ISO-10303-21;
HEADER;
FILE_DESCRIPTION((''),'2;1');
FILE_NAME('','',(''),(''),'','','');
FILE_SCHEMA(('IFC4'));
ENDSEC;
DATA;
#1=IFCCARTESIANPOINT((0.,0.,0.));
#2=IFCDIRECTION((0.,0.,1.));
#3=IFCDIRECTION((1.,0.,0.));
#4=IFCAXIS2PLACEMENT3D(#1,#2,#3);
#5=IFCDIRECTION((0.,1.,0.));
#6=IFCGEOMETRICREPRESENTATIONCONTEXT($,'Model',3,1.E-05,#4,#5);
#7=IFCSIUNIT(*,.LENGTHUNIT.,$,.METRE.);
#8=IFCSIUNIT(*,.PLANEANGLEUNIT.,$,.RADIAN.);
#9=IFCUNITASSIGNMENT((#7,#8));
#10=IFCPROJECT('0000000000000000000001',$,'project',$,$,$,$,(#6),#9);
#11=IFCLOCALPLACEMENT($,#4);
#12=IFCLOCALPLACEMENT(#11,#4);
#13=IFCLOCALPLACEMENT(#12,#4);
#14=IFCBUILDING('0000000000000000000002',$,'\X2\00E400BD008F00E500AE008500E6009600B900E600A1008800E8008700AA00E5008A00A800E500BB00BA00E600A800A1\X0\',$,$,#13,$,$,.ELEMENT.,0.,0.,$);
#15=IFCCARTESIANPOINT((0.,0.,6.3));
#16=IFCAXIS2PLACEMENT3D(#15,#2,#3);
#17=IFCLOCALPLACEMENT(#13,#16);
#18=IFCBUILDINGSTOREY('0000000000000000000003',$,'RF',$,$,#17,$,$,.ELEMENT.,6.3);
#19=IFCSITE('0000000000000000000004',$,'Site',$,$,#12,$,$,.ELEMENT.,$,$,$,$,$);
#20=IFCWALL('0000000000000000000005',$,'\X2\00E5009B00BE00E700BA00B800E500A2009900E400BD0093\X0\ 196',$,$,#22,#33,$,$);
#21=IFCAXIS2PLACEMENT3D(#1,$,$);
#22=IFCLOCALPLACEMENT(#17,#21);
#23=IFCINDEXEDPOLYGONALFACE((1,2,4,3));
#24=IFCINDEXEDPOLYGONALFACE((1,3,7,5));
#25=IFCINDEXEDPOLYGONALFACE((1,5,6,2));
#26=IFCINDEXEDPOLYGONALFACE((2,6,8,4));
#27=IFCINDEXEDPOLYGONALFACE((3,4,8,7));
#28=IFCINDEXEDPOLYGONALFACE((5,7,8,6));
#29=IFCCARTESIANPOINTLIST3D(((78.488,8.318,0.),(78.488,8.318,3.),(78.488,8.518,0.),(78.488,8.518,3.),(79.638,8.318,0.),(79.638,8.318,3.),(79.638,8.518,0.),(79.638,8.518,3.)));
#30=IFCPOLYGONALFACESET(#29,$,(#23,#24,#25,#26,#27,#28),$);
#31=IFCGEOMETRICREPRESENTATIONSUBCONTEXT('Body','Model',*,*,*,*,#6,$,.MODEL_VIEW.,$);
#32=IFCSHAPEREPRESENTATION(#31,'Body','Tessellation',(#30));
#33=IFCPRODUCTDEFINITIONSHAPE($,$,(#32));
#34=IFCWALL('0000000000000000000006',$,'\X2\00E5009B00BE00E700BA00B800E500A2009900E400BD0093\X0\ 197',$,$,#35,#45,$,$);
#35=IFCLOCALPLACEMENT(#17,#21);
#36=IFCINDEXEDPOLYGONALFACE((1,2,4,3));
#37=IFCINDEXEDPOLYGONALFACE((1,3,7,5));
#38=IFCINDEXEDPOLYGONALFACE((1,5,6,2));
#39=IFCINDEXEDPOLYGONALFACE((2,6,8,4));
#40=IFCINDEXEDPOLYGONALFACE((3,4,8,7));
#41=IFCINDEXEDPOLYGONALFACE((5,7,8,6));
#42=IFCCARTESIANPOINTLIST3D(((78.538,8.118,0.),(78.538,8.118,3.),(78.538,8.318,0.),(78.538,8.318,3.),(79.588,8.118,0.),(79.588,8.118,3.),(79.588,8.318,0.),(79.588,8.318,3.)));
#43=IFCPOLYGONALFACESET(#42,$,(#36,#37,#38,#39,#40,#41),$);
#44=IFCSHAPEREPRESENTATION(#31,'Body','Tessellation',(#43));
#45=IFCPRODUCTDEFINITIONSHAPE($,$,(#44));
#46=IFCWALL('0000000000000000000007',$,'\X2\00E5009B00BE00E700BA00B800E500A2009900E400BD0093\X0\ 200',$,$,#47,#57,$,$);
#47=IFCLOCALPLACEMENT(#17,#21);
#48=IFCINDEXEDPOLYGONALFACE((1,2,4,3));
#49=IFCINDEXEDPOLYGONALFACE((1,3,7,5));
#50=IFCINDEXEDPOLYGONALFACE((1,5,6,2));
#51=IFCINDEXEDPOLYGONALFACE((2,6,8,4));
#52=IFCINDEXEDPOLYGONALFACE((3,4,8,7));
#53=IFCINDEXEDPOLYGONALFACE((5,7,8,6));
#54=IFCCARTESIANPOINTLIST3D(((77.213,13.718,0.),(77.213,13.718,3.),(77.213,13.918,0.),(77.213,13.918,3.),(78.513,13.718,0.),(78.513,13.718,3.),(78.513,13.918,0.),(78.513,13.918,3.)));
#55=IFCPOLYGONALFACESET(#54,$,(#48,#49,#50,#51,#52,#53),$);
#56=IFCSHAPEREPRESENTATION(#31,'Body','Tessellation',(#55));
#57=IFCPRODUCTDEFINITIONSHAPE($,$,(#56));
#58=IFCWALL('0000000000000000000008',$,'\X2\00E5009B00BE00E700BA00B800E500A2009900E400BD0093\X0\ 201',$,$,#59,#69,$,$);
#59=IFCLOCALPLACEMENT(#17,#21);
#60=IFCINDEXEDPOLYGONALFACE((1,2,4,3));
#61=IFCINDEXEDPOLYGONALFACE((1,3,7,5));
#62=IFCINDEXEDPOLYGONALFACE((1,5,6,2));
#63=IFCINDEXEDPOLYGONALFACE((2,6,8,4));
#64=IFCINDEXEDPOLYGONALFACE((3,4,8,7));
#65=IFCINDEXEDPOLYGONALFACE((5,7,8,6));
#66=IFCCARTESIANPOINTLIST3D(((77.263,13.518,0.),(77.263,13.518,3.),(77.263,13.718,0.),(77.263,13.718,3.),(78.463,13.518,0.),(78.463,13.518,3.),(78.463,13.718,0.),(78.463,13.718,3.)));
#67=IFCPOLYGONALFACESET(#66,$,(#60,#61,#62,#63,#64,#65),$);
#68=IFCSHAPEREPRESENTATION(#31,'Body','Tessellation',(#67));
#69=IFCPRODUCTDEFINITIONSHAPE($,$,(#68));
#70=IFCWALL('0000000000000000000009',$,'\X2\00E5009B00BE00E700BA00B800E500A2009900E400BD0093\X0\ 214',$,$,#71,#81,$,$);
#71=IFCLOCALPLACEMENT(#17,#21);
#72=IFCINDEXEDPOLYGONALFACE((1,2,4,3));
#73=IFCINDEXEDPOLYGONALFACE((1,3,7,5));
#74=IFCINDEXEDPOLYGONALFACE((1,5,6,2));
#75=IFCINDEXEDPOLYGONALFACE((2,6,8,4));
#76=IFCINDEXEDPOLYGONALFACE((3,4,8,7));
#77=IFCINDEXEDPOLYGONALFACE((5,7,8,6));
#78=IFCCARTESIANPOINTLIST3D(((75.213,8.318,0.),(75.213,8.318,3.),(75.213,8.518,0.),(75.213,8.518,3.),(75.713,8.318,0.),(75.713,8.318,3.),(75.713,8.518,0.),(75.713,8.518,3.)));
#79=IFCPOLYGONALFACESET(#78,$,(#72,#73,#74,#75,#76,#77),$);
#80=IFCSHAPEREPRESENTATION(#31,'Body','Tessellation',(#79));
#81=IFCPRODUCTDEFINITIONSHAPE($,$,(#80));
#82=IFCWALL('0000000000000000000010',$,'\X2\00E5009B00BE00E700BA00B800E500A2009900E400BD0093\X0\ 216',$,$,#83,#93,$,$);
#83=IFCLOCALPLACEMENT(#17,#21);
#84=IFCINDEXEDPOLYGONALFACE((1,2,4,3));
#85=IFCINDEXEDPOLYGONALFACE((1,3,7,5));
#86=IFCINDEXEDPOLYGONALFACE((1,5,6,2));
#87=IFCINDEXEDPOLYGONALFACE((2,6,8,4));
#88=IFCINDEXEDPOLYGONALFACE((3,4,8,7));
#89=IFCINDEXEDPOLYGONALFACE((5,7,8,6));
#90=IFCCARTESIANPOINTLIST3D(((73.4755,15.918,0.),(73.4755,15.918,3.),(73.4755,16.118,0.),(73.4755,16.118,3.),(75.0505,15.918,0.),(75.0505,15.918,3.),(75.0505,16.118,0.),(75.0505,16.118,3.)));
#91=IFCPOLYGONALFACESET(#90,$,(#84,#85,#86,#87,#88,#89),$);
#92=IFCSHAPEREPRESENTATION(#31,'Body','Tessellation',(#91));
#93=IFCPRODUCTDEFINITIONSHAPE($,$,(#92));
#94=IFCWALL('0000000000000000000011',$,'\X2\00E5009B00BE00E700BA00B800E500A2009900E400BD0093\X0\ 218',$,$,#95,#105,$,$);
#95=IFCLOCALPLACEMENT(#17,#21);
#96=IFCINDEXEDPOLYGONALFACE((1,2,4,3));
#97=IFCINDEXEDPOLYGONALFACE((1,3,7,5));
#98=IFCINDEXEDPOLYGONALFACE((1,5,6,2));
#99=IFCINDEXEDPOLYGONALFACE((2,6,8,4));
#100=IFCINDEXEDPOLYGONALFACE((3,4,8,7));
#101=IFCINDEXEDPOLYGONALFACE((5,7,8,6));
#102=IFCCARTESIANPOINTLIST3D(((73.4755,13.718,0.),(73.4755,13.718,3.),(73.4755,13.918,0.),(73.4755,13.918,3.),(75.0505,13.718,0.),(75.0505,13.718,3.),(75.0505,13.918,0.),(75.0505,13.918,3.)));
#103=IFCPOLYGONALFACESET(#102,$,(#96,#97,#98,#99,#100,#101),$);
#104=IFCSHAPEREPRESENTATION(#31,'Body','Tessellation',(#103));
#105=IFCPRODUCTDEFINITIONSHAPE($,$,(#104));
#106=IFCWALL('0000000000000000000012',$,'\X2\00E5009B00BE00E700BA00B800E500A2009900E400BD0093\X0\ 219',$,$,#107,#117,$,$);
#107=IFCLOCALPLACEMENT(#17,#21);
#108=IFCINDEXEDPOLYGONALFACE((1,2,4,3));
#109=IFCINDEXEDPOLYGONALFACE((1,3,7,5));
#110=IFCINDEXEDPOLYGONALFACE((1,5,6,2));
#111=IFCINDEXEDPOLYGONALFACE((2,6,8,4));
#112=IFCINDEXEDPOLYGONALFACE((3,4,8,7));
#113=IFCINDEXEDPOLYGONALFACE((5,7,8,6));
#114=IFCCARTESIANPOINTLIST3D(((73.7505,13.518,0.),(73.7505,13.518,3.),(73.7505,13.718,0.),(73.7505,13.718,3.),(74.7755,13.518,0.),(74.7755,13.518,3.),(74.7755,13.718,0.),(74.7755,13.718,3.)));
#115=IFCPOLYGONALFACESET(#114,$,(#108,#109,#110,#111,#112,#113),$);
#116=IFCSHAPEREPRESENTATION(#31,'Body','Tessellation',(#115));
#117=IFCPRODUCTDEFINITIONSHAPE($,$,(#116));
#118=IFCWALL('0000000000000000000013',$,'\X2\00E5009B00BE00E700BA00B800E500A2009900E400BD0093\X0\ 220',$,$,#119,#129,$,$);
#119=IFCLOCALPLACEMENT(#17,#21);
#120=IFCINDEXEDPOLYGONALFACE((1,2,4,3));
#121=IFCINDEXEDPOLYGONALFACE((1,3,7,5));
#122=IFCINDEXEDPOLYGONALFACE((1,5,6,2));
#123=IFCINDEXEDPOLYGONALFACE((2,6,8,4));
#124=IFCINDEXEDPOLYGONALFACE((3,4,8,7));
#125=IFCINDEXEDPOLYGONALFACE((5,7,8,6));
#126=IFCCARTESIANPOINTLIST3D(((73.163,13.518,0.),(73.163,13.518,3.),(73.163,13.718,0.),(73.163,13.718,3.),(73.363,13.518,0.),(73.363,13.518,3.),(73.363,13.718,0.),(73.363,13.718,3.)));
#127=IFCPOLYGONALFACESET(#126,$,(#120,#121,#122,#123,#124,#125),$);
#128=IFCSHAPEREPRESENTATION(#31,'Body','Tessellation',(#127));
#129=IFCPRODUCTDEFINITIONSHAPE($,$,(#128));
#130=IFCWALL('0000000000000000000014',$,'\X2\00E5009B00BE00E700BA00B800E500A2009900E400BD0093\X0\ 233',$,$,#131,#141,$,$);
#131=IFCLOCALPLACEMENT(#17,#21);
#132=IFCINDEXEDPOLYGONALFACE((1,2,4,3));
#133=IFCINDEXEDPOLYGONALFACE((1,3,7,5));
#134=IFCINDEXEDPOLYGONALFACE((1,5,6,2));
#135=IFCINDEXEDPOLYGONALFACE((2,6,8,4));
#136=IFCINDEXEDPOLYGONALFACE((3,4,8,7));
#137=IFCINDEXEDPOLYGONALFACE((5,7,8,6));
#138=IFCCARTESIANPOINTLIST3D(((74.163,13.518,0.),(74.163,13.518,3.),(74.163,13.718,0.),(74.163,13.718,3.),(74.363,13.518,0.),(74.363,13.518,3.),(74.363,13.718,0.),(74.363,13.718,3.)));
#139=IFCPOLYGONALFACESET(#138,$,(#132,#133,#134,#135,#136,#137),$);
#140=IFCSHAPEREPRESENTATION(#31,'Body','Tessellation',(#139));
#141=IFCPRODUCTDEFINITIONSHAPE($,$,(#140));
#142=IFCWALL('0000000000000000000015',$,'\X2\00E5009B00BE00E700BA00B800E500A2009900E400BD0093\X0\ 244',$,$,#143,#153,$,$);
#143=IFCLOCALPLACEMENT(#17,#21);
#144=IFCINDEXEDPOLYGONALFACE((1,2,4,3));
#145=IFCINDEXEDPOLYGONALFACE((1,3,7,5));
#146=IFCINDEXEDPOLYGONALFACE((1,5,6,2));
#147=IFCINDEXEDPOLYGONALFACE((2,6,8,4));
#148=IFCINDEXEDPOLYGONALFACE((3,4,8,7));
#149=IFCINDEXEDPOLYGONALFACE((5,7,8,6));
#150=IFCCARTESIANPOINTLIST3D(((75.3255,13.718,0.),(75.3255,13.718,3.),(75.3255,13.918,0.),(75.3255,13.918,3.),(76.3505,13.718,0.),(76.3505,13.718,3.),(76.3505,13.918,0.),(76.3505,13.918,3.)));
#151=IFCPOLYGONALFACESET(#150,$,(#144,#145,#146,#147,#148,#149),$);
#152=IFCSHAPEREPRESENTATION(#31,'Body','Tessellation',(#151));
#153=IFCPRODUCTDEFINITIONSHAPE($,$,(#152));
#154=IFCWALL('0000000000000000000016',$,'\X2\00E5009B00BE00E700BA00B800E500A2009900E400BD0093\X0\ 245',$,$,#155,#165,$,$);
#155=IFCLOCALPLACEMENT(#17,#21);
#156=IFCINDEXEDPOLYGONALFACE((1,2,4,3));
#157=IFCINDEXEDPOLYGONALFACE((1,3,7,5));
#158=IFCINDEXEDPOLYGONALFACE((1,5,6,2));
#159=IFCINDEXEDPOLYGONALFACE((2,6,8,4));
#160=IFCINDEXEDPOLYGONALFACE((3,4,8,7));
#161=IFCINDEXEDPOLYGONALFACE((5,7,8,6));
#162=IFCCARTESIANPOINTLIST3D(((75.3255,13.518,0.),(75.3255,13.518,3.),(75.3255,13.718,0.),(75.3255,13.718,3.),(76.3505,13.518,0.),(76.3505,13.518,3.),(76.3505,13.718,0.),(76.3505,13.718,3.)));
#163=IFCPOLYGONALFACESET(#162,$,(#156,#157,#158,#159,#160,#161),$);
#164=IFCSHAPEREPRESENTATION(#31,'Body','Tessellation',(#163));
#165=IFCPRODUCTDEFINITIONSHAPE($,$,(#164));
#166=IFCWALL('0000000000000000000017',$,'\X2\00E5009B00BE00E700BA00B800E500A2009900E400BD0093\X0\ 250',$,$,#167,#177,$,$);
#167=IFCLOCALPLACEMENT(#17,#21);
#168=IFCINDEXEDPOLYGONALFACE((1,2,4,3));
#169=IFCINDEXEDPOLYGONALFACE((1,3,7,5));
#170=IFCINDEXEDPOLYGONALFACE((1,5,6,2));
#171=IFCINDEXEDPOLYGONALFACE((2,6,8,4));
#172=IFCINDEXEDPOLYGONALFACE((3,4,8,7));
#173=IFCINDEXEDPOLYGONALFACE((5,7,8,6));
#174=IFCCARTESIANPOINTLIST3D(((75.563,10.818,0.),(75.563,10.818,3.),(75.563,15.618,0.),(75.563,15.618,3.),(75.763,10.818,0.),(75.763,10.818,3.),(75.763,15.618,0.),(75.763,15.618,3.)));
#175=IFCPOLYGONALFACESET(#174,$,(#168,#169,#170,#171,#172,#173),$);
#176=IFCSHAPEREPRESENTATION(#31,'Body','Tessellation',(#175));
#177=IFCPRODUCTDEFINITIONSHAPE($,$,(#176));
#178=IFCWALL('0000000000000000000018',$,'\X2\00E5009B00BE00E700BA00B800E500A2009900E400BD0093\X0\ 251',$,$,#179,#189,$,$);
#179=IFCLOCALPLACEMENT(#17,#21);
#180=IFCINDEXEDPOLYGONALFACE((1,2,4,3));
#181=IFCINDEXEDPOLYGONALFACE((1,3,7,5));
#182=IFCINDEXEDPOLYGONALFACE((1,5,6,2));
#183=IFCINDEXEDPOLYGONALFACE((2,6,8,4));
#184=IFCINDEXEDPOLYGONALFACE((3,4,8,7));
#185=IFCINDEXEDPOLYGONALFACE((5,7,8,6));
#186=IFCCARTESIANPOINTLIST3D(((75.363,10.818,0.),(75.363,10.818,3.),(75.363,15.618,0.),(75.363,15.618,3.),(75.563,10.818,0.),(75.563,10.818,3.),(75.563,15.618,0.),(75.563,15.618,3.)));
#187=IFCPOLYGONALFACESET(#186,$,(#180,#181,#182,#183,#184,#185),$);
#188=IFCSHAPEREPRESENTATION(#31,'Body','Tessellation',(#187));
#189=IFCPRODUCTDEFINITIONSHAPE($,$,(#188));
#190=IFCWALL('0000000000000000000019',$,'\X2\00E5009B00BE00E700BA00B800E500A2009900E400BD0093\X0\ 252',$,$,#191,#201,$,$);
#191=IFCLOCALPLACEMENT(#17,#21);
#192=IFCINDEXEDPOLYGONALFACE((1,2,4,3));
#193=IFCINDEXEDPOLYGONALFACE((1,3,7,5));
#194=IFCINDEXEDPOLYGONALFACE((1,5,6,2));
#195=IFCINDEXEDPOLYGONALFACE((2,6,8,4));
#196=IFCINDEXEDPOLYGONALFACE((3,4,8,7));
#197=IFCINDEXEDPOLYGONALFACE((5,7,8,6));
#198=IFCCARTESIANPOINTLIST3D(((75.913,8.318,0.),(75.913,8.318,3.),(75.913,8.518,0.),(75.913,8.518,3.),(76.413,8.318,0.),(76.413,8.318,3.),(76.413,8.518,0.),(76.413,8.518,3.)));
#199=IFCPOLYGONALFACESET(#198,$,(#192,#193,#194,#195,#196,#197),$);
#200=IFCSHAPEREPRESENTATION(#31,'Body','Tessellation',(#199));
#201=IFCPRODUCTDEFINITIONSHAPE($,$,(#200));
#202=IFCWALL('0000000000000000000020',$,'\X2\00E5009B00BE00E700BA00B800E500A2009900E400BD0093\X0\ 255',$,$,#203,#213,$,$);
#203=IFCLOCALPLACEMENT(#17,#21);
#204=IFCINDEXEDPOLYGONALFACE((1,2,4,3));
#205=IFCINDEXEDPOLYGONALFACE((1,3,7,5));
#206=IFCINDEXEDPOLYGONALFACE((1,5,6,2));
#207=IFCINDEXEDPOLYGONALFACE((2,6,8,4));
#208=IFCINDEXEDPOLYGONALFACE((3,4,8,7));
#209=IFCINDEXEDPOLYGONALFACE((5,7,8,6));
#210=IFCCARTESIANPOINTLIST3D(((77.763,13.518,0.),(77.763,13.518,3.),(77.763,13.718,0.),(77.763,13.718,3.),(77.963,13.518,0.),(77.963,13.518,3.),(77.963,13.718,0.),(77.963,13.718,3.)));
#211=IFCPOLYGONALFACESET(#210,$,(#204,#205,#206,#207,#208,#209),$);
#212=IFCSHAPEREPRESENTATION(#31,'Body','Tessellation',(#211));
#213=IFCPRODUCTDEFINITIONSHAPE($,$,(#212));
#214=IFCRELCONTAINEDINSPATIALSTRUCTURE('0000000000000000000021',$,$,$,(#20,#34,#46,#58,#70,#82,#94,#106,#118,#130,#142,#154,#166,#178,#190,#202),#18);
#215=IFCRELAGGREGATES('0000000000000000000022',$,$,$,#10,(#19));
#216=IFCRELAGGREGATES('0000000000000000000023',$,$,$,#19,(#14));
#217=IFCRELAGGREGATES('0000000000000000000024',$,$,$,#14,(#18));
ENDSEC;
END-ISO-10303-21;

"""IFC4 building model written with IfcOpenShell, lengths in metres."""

from ifc_helpers import new_model, si_unit, direction, frame, frame_2d, origin_with_axes, place, context, subcontext, project, spatial, rectangle, extrude, element, save


model = new_model("IFC4")

# Units and contexts
model_context = context("Model", 3, precision=1e-05, world=origin_with_axes(), true_north=direction((0.0, 1.0, 0.0)))
body_context = subcontext(model_context, "Body", "Model", "MODEL_VIEW")
ifc_project = project(units=[si_unit("LENGTHUNIT", "METRE"), si_unit("PLANEANGLEUNIT", "RADIAN")], contexts=[model_context])

# Site, building, storey
placement = place(None, origin_with_axes())
site_placement = place(placement, origin_with_axes())
site = spatial("IfcSite", under=ifc_project, at=site_placement, Name="Site", CompositionType="ELEMENT")
building_placement = place(site_placement, origin_with_axes())
building = spatial("IfcBuilding", under=site, at=building_placement, Name="ä½\u008få®\u0085æ\u0096¹æ¡\u0088è\u0087ªå\u008a¨å»ºæ¨¡", CompositionType="ELEMENT", ElevationOfRefHeight=0.0, ElevationOfTerrain=0.0)
storey_placement = place(building_placement, frame((0.0, 0.0, 6.3), z_axis=(0.0, 0.0, 1.0), x_axis=(1.0, 0.0, 0.0)))
storey = spatial("IfcBuildingStorey", under=building, at=storey_placement, Name="RF", CompositionType="ELEMENT", Elevation=6.3)

# Walls
wall_1_placement = place(storey_placement, frame((79.063, 8.418, 0.0), z_axis=(0.0, 0.0, 1.0), x_axis=(-1.0, 0.0, 0.0)))
element("IfcWall", 1, at=wall_1_placement, inside=storey, Name="å\u009b¾çº¸å¢\u0099ä½\u0093 196", context=body_context, shape_type="SweptSolid", body=[
    extrude(rectangle(XDim=1.15, YDim=0.2, at=frame_2d((0.0, 0.0), x_axis=(1.0, 0.0, 0.0))), frame((0.0, 0.0, 0.0), z_axis=(0.0, 0.0, 1.0)), (0.0, 0.0, 1.0), 3.0),
])
wall_2_placement = place(storey_placement, frame((79.063, 8.218, 0.0), z_axis=(0.0, 0.0, 1.0), x_axis=(-1.0, 0.0, 0.0)))
element("IfcWall", 2, at=wall_2_placement, inside=storey, Name="å\u009b¾çº¸å¢\u0099ä½\u0093 197", context=body_context, shape_type="SweptSolid", body=[
    extrude(rectangle(XDim=1.05, YDim=0.2, at=frame_2d((0.0, 0.0), x_axis=(1.0, 0.0, 0.0))), frame((0.0, 0.0, 0.0), z_axis=(0.0, 0.0, 1.0)), (0.0, 0.0, 1.0), 3.0),
])
wall_3_placement = place(storey_placement, frame((77.863, 13.818, 0.0), z_axis=(0.0, 0.0, 1.0), x_axis=(1.0, 0.0, 0.0)))
element("IfcWall", 3, at=wall_3_placement, inside=storey, Name="å\u009b¾çº¸å¢\u0099ä½\u0093 200", context=body_context, shape_type="SweptSolid", body=[
    extrude(rectangle(XDim=1.3, YDim=0.2, at=frame_2d((0.0, 0.0), x_axis=(1.0, 0.0, 0.0))), frame((0.0, 0.0, 0.0), z_axis=(0.0, 0.0, 1.0)), (0.0, 0.0, 1.0), 3.0),
])
wall_4_placement = place(storey_placement, frame((77.863, 13.618, 0.0), z_axis=(0.0, 0.0, 1.0), x_axis=(1.0, 0.0, 0.0)))
element("IfcWall", 4, at=wall_4_placement, inside=storey, Name="å\u009b¾çº¸å¢\u0099ä½\u0093 201", context=body_context, shape_type="SweptSolid", body=[
    extrude(rectangle(XDim=1.2, YDim=0.2, at=frame_2d((0.0, 0.0), x_axis=(1.0, 0.0, 0.0))), frame((0.0, 0.0, 0.0), z_axis=(0.0, 0.0, 1.0)), (0.0, 0.0, 1.0), 3.0),
])
wall_5_placement = place(storey_placement, frame((75.463, 8.418, 0.0), z_axis=(0.0, 0.0, 1.0), x_axis=(-1.0, 0.0, 0.0)))
element("IfcWall", 5, at=wall_5_placement, inside=storey, Name="å\u009b¾çº¸å¢\u0099ä½\u0093 214", context=body_context, shape_type="SweptSolid", body=[
    extrude(rectangle(XDim=0.5, YDim=0.2, at=frame_2d((0.0, 0.0), x_axis=(1.0, 0.0, 0.0))), frame((0.0, 0.0, 0.0), z_axis=(0.0, 0.0, 1.0)), (0.0, 0.0, 1.0), 3.0),
])
for number, where, z_axis, x_axis, name in (
    (6, (74.263, 16.018, 0.0), (0.0, 0.0, 1.0), (1.0, 0.0, 0.0), "å\u009b¾çº¸å¢\u0099ä½\u0093 216"),
    (7, (74.263, 13.818, 0.0), (0.0, 0.0, 1.0), (1.0, 0.0, 0.0), "å\u009b¾çº¸å¢\u0099ä½\u0093 218"),
):
    element("IfcWall", number, at=place(storey_placement, frame(where, z_axis=z_axis, x_axis=x_axis)), inside=storey, Name=name, context=body_context, shape_type="SweptSolid", body=[
        extrude(rectangle(XDim=1.575, YDim=0.2, at=frame_2d((0.0, 0.0), x_axis=(1.0, 0.0, 0.0))), frame((0.0, 0.0, 0.0), z_axis=(0.0, 0.0, 1.0)), (0.0, 0.0, 1.0), 3.0),
    ])
wall_6_placement = place(storey_placement, frame((74.263, 13.618, 0.0), z_axis=(0.0, 0.0, 1.0), x_axis=(1.0, 0.0, 0.0)))
element("IfcWall", 8, at=wall_6_placement, inside=storey, Name="å\u009b¾çº¸å¢\u0099ä½\u0093 219", context=body_context, shape_type="SweptSolid", body=[
    extrude(rectangle(XDim=1.025, YDim=0.2, at=frame_2d((0.0, 0.0), x_axis=(1.0, 0.0, 0.0))), frame((0.0, 0.0, 0.0), z_axis=(0.0, 0.0, 1.0)), (0.0, 0.0, 1.0), 3.0),
])
for number, where, z_axis, x_axis, name in (
    (9, (73.263, 13.618, 0.0), (0.0, 0.0, 1.0), (0.0, 1.0, 0.0), "å\u009b¾çº¸å¢\u0099ä½\u0093 220"),
    (10, (74.263, 13.618, 0.0), (0.0, 0.0, 1.0), (0.0, 1.0, 0.0), "å\u009b¾çº¸å¢\u0099ä½\u0093 233"),
):
    element("IfcWall", number, at=place(storey_placement, frame(where, z_axis=z_axis, x_axis=x_axis)), inside=storey, Name=name, context=body_context, shape_type="SweptSolid", body=[
        extrude(rectangle(XDim=0.2, YDim=0.2, at=frame_2d((0.0, 0.0), x_axis=(1.0, 0.0, 0.0))), frame((0.0, 0.0, 0.0), z_axis=(0.0, 0.0, 1.0)), (0.0, 0.0, 1.0), 3.0),
    ])
for number, where, z_axis, x_axis, name in (
    (11, (75.838, 13.818, 0.0), (0.0, 0.0, 1.0), (1.0, 0.0, 0.0), "å\u009b¾çº¸å¢\u0099ä½\u0093 244"),
    (12, (75.838, 13.618, 0.0), (0.0, 0.0, 1.0), (1.0, 0.0, 0.0), "å\u009b¾çº¸å¢\u0099ä½\u0093 245"),
):
    element("IfcWall", number, at=place(storey_placement, frame(where, z_axis=z_axis, x_axis=x_axis)), inside=storey, Name=name, context=body_context, shape_type="SweptSolid", body=[
        extrude(rectangle(XDim=1.025, YDim=0.2, at=frame_2d((0.0, 0.0), x_axis=(1.0, 0.0, 0.0))), frame((0.0, 0.0, 0.0), z_axis=(0.0, 0.0, 1.0)), (0.0, 0.0, 1.0), 3.0),
    ])
for number, where, z_axis, x_axis, name in (
    (13, (75.663, 13.218, 0.0), (0.0, 0.0, 1.0), (0.0, -1.0, 0.0), "å\u009b¾çº¸å¢\u0099ä½\u0093 250"),
    (14, (75.463, 13.218, 0.0), (0.0, 0.0, 1.0), (0.0, -1.0, 0.0), "å\u009b¾çº¸å¢\u0099ä½\u0093 251"),
):
    element("IfcWall", number, at=place(storey_placement, frame(where, z_axis=z_axis, x_axis=x_axis)), inside=storey, Name=name, context=body_context, shape_type="SweptSolid", body=[
        extrude(rectangle(XDim=4.8, YDim=0.2, at=frame_2d((0.0, 0.0), x_axis=(1.0, 0.0, 0.0))), frame((0.0, 0.0, 0.0), z_axis=(0.0, 0.0, 1.0)), (0.0, 0.0, 1.0), 3.0),
    ])
wall_7_placement = place(storey_placement, frame((76.163, 8.418, 0.0), z_axis=(0.0, 0.0, 1.0), x_axis=(-1.0, 0.0, 0.0)))
element("IfcWall", 15, at=wall_7_placement, inside=storey, Name="å\u009b¾çº¸å¢\u0099ä½\u0093 252", context=body_context, shape_type="SweptSolid", body=[
    extrude(rectangle(XDim=0.5, YDim=0.2, at=frame_2d((0.0, 0.0), x_axis=(1.0, 0.0, 0.0))), frame((0.0, 0.0, 0.0), z_axis=(0.0, 0.0, 1.0)), (0.0, 0.0, 1.0), 3.0),
])
for number, where, z_axis, x_axis, name in (
    (16, (77.863, 13.618, 0.0), (0.0, 0.0, 1.0), (0.0, 1.0, 0.0), "å\u009b¾çº¸å¢\u0099ä½\u0093 255"),
):
    element("IfcWall", number, at=place(storey_placement, frame(where, z_axis=z_axis, x_axis=x_axis)), inside=storey, Name=name, context=body_context, shape_type="SweptSolid", body=[
        extrude(rectangle(XDim=0.2, YDim=0.2, at=frame_2d((0.0, 0.0), x_axis=(1.0, 0.0, 0.0))), frame((0.0, 0.0, 0.0), z_axis=(0.0, 0.0, 1.0)), (0.0, 0.0, 1.0), 3.0),
    ])

save(model, "model.ifc")
